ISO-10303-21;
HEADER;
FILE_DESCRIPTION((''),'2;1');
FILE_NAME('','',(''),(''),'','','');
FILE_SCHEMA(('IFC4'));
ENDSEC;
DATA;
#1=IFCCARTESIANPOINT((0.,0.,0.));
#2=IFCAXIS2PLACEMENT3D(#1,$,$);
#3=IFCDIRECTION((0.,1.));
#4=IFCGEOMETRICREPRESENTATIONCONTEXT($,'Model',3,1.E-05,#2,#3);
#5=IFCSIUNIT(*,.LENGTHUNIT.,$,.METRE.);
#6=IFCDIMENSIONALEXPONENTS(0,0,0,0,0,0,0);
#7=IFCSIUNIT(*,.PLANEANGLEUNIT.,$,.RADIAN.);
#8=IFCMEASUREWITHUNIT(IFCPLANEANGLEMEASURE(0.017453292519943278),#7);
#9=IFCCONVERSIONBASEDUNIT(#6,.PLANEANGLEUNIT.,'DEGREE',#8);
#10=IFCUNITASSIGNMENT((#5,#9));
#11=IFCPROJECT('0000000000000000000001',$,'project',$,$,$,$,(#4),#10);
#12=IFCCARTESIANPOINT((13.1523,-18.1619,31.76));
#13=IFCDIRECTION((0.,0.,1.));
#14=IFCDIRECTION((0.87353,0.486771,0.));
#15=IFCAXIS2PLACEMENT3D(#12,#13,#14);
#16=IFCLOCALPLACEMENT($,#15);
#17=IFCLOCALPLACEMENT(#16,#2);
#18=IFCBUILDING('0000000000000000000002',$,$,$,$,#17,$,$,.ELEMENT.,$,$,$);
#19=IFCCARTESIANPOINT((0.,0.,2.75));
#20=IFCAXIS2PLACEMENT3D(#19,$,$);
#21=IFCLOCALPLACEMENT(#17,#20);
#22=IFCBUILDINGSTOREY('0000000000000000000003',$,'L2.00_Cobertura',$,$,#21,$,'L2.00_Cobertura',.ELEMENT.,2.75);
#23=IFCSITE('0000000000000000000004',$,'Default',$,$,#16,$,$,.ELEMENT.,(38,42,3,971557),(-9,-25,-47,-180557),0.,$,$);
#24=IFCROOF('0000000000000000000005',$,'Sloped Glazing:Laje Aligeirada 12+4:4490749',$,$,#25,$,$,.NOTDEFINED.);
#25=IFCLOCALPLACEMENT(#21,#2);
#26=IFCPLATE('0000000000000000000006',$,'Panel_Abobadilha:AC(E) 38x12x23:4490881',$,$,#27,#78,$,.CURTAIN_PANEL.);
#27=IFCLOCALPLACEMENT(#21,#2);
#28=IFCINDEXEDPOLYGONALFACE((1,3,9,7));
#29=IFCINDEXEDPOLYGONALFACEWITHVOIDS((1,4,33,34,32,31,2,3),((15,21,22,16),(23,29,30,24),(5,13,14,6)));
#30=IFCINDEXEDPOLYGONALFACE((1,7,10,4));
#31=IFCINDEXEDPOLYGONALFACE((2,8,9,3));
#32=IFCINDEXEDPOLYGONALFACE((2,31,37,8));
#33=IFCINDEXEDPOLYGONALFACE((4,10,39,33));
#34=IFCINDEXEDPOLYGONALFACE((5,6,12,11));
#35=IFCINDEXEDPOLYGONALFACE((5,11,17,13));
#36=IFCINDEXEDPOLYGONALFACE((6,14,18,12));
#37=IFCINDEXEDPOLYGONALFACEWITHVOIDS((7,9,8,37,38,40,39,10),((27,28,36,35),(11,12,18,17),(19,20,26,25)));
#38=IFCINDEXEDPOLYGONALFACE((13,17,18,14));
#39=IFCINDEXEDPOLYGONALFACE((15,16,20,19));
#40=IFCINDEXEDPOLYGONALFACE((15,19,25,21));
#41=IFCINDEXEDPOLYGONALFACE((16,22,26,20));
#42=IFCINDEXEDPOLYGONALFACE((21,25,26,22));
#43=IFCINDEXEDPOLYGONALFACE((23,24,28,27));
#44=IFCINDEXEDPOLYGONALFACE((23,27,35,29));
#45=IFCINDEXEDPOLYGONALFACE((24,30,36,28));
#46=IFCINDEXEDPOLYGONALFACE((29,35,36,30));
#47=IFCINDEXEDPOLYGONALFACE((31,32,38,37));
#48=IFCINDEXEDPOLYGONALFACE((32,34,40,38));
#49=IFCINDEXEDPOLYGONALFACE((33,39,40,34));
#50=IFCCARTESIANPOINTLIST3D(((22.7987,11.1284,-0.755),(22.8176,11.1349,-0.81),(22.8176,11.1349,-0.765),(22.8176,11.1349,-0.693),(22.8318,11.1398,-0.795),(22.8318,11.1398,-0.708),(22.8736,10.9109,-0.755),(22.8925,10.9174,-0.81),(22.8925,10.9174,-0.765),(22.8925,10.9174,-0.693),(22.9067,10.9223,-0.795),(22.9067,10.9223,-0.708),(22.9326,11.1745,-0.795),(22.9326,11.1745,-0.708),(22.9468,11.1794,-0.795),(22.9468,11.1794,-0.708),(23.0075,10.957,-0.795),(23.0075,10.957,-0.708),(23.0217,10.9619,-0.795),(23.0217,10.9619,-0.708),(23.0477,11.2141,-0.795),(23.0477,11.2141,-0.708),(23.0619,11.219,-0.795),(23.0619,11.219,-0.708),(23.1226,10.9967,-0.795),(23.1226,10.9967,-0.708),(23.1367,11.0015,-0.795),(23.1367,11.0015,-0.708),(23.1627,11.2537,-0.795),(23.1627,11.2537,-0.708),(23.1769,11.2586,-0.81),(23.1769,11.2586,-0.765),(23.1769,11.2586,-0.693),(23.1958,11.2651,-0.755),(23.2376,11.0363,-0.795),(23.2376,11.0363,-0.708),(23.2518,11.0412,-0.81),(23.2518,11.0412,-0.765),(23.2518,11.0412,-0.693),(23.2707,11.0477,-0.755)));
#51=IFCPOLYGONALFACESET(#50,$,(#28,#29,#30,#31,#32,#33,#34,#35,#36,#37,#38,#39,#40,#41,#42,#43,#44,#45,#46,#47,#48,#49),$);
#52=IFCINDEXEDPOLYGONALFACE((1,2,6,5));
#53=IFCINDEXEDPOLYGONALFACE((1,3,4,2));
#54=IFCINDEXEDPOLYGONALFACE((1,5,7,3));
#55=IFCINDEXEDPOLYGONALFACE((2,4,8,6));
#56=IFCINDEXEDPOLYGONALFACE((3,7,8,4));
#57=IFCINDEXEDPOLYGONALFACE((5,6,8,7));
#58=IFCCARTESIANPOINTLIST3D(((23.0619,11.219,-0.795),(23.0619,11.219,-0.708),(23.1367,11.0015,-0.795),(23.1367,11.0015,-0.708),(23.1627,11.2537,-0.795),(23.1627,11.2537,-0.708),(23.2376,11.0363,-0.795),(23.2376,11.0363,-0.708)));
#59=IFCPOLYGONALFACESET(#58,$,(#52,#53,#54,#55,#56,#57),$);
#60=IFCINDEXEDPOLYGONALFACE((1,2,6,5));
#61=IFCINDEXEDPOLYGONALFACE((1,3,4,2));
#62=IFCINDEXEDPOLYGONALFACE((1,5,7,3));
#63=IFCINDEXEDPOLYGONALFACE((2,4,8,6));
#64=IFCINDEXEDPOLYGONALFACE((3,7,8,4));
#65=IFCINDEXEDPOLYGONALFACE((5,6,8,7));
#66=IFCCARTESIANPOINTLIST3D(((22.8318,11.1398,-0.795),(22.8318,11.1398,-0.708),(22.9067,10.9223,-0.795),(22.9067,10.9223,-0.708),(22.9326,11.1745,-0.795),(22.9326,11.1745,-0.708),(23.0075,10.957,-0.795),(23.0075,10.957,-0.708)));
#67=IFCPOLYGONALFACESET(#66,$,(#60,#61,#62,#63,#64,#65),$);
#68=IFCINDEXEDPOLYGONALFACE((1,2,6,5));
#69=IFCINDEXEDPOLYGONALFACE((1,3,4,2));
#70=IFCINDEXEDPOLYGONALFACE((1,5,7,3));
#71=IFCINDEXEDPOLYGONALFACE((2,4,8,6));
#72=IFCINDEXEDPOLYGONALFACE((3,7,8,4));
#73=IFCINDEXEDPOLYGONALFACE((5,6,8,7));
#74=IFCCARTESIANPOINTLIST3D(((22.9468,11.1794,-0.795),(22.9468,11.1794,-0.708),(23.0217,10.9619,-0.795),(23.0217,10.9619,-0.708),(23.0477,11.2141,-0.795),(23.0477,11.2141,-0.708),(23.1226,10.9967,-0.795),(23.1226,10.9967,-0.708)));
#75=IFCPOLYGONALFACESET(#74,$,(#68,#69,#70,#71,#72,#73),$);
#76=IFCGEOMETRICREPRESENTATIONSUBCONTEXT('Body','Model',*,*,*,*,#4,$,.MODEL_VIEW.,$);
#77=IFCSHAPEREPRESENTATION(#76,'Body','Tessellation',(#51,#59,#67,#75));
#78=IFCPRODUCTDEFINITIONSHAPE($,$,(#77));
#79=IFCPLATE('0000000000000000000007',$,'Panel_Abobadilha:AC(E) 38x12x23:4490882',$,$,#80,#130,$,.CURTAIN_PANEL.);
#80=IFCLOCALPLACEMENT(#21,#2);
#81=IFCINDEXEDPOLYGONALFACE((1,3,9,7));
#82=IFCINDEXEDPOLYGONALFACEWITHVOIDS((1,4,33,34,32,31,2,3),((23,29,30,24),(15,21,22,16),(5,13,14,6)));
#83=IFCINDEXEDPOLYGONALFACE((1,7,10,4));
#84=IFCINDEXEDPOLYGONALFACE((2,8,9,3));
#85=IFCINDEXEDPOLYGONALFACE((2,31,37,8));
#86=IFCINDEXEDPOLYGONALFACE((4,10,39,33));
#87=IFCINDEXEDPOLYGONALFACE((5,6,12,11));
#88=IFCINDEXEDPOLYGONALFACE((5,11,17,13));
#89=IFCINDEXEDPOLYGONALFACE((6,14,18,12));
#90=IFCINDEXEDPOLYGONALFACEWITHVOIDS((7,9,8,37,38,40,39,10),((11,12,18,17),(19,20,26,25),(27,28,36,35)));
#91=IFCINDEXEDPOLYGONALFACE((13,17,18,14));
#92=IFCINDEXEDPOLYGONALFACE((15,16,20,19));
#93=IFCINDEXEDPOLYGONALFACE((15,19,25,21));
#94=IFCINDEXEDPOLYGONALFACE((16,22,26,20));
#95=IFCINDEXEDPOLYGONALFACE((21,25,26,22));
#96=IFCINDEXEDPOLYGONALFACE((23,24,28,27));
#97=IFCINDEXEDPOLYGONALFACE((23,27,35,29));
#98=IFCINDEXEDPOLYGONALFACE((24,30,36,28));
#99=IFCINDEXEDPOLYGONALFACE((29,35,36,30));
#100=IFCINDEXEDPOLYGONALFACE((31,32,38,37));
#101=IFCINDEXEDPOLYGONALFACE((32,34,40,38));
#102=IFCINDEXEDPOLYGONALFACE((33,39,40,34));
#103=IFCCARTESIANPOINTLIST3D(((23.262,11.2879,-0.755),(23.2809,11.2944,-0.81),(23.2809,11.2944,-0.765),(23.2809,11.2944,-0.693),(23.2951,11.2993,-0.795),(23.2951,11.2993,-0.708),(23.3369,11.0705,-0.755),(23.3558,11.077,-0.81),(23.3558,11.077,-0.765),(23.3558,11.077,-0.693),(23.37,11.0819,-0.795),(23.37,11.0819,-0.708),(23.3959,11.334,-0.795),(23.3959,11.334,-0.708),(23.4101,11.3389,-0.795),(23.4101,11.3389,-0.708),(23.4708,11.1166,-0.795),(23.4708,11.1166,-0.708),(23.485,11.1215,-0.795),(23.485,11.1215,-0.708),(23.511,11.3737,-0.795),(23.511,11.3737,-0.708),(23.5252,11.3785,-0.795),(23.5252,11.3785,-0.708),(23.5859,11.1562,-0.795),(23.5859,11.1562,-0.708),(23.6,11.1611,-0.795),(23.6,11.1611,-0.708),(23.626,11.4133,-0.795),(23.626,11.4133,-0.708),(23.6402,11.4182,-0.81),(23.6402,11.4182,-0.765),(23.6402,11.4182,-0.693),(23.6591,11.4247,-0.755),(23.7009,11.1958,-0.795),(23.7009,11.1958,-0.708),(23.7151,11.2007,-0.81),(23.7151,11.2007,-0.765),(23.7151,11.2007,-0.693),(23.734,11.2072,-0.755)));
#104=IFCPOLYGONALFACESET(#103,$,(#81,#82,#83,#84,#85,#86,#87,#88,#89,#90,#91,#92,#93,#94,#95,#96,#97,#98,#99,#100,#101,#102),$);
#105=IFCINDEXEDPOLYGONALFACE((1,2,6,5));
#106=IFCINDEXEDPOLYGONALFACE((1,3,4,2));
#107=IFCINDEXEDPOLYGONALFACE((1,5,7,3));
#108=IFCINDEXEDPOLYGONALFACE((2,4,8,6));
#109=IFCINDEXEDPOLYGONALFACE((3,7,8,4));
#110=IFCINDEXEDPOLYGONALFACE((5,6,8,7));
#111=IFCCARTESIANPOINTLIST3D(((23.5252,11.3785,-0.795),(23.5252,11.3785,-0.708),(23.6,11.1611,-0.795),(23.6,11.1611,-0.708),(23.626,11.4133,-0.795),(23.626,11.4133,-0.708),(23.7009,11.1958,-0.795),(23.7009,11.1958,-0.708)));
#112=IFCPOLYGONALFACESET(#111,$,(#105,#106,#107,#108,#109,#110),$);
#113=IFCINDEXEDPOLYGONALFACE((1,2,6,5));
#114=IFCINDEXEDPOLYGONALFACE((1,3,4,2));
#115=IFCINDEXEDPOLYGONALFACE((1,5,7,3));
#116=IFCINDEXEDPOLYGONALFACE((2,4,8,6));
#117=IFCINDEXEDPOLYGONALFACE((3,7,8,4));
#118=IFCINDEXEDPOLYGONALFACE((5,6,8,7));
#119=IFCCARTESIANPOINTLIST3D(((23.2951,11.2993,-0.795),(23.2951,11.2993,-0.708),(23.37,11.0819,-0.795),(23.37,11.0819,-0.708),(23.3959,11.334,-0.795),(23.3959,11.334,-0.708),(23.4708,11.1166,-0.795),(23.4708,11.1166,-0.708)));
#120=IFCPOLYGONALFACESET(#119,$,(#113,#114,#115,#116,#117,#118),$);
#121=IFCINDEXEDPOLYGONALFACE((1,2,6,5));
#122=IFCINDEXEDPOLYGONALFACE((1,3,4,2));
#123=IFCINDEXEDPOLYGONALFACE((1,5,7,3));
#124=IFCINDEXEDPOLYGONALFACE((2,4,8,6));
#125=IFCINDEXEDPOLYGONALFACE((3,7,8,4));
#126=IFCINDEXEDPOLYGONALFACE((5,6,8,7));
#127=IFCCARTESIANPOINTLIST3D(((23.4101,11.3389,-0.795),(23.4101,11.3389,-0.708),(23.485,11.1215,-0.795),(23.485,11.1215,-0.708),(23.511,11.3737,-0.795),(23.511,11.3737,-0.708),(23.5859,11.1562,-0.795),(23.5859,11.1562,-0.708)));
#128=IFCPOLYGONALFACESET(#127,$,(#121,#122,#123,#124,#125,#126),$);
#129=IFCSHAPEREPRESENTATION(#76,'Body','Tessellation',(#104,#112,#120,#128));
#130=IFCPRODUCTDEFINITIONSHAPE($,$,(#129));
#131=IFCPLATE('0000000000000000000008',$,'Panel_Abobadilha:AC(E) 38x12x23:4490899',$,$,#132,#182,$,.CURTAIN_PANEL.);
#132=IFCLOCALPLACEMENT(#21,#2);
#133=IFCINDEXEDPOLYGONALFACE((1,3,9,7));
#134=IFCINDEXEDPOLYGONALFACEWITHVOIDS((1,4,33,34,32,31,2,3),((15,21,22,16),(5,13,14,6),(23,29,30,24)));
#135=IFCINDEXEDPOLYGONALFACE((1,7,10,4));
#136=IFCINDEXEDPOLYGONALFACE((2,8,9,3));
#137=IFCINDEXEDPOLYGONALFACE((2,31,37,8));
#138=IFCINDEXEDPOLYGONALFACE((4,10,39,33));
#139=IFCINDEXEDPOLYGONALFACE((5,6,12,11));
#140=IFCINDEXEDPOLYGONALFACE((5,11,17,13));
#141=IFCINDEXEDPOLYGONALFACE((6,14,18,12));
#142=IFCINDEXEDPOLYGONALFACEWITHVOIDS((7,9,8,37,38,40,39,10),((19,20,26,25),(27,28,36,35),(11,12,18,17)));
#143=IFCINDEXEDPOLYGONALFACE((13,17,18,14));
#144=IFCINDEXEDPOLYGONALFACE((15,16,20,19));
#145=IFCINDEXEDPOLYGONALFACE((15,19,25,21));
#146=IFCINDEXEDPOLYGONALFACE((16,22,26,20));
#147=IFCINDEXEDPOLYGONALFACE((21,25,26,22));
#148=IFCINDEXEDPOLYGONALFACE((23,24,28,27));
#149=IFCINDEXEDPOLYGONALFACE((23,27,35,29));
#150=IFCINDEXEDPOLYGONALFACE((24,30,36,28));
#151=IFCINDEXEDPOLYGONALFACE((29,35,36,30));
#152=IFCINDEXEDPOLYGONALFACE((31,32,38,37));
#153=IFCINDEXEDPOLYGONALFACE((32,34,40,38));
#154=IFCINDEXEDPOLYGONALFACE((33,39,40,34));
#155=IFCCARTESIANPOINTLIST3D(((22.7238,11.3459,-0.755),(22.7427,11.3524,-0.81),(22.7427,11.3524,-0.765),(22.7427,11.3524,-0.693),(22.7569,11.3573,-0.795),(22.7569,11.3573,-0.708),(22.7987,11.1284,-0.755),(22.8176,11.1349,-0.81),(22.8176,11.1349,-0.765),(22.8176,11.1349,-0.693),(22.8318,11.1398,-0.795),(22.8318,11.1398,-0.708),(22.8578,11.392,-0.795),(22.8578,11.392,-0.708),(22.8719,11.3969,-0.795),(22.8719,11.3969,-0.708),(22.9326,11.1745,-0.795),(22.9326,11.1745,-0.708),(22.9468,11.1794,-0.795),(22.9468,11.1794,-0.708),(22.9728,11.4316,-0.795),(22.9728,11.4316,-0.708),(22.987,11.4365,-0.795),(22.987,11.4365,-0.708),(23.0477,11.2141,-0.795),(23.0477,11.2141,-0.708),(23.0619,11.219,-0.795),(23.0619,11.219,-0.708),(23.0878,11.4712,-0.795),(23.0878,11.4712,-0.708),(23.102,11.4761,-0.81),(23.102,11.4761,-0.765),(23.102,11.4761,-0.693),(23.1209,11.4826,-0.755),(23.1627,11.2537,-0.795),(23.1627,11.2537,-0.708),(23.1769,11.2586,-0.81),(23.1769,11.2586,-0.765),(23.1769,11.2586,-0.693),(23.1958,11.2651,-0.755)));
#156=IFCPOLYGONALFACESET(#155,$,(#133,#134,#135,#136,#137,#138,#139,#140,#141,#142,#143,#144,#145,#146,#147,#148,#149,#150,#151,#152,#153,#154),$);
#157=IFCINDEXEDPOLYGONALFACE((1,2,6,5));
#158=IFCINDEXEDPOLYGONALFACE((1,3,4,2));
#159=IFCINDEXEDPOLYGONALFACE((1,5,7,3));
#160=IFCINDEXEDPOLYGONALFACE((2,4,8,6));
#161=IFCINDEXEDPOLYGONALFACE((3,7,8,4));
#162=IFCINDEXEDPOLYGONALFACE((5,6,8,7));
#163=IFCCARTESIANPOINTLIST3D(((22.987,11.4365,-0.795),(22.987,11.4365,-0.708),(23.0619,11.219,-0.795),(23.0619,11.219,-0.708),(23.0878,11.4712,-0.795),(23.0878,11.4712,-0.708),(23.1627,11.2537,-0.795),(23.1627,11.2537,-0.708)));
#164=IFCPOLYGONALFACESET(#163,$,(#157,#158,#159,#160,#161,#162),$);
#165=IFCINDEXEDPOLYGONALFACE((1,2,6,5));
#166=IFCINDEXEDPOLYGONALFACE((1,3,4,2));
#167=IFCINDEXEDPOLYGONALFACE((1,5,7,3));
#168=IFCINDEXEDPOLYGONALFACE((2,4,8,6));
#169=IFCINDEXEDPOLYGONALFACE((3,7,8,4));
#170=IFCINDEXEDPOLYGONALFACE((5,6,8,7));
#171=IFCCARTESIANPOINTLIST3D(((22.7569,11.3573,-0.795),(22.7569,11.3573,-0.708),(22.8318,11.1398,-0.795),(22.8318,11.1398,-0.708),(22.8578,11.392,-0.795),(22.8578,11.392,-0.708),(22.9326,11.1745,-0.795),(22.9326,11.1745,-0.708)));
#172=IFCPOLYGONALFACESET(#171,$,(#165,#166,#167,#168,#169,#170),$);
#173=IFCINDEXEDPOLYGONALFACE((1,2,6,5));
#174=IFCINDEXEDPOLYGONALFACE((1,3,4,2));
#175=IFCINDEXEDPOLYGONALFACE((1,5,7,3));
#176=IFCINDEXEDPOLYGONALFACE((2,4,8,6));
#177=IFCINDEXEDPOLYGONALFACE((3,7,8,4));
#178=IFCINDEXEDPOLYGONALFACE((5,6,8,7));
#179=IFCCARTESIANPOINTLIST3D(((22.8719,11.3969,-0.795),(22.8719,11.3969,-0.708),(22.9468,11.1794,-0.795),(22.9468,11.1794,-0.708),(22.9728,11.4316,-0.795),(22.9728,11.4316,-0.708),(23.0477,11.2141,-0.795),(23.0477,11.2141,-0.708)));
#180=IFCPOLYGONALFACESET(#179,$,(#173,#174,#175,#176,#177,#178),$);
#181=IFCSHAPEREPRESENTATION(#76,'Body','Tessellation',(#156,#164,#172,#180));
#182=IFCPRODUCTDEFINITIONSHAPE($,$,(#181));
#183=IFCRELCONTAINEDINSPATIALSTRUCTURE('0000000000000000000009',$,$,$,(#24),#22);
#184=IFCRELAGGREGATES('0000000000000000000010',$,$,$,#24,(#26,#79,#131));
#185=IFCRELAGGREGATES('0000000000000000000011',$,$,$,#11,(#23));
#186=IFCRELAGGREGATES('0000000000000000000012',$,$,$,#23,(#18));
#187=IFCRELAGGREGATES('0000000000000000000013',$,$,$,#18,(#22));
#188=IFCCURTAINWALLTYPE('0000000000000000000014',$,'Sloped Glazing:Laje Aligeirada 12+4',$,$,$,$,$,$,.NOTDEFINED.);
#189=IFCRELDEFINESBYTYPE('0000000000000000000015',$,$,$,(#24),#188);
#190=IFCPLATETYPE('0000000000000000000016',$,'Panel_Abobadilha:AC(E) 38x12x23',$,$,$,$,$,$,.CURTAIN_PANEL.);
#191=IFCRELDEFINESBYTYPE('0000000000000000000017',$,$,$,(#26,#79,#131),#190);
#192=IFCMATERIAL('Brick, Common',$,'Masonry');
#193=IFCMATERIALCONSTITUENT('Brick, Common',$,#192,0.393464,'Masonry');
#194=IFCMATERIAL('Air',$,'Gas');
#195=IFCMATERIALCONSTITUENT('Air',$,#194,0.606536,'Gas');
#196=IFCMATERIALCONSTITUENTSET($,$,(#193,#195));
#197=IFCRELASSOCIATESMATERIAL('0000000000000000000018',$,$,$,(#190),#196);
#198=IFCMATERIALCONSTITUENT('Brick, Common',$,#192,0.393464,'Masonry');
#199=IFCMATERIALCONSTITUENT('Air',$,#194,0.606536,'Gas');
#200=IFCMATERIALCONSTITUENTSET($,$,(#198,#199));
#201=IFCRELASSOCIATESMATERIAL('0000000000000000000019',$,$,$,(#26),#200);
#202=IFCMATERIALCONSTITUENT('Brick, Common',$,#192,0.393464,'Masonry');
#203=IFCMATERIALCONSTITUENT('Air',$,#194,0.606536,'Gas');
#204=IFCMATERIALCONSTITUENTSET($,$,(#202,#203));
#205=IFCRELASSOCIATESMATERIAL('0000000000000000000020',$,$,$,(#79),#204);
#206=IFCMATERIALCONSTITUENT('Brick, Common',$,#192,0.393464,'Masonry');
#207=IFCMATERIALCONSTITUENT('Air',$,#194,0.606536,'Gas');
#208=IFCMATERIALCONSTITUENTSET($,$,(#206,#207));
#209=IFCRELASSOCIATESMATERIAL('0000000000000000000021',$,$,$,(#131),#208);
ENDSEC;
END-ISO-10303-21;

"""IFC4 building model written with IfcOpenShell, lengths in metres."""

from ifc_helpers import new_model, entity, si_unit, converted_unit, direction, frame, origin, place, context, subcontext, project, spatial, indexed_curve, outline, extrude, source, transform, mapped, material, constituent, constituent_set, type_object, type_shapes, element, aggregate, save


model = new_model("IFC4")

# Units and contexts
model_context = context("Model", 3, precision=1e-05, world=origin(), true_north=direction((0.0, 1.0)))
body_context = subcontext(model_context, "Body", "Model", "MODEL_VIEW")
ifc_project = project(units=[si_unit("LENGTHUNIT", "METRE"), converted_unit("PLANEANGLEUNIT", "DEGREE", entity("IfcPlaneAngleMeasure", 0.017453292519943278), si_unit("PLANEANGLEUNIT", "RADIAN"), dimensions=[0, 0, 0, 0, 0, 0, 0])], contexts=[model_context])

# Site, building, storey
site_placement = place(None, frame((13.1523, -18.1619, 31.76), z_axis=(0.0, 0.0, 1.0), x_axis=(0.87353, 0.486771, 0.0)))
site = spatial("IfcSite", under=ifc_project, at=site_placement, Name="Default", CompositionType="ELEMENT", RefLatitude=(38, 42, 3, 971557), RefLongitude=(-9, -25, -47, -180557), RefElevation=0.0)
building_placement = place(site_placement, origin())
building = spatial("IfcBuilding", under=site, at=building_placement, CompositionType="ELEMENT")
storey_placement = place(building_placement, frame((0.0, 0.0, 2.75)))
storey = spatial("IfcBuildingStorey", under=building, at=storey_placement, Name="L2.00_Cobertura", LongName="L2.00_Cobertura", CompositionType="ELEMENT", Elevation=2.75)

# Roof, plates
curtain_wall_type = type_object("IfcCurtainWallType", Name="Sloped Glazing:Laje Aligeirada 12+4", PredefinedType="NOTDEFINED")
roof_placement = place(storey_placement, frame((0.0, 0.0, -2.75)))
roof = element("IfcRoof", 1, at=roof_placement, inside=storey, type_object=curtain_wall_type, Name="Sloped Glazing:Laje Aligeirada 12+4:4490749", PredefinedType="NOTDEFINED")
ifc_material_1 = material(Name="Brick, Common", Category="Masonry")
ifc_material_2 = material(Name="Air", Category="Gas")
ifc_constituent_1 = constituent(ifc_material_1, Name="Brick, Common", Category="Masonry", fraction=0.393464)
ifc_constituent_2 = constituent(ifc_material_2, Name="Air", Category="Gas", fraction=0.606536)
ifc_constituent_set_1 = constituent_set(constituents=[ifc_constituent_1, ifc_constituent_2])
plate_type_1 = type_object("IfcPlateType", Name="Panel_Abobadilha:AC(E) 38x12x23", PredefinedType="CURTAIN_PANEL", material=ifc_constituent_set_1)
shared_shape_1 = source(origin(), body_context, "Body", "SweptSolid", [
    extrude(outline(indexed_curve([(-0.19, -0.0543), (0.19, -0.0543), (0.19, -0.0093), (0.21, 0.0007), (0.19, 0.0628), (-0.19, 0.0628), (-0.21, 0.0007), (-0.19, -0.0093), (-0.19, -0.0543)], self_intersect=False), holes=[indexed_curve([(-0.0683, 0.0477), (-0.0683, -0.0393), (-0.175, -0.0393), (-0.175, 0.0477), (-0.0683, 0.0477)], self_intersect=False), indexed_curve([(0.0533, 0.0477), (0.0533, -0.0393), (-0.0533, -0.0393), (-0.0533, 0.0477), (0.0533, 0.0477)], self_intersect=False), indexed_curve([(0.175, 0.0477), (0.175, -0.0393), (0.0683, -0.0393), (0.0683, 0.0477), (0.175, 0.0477)], self_intersect=False)]), frame((0.0, 0.0543, 0.0)), (0.0, 0.0, 1.0), 0.23),
    extrude(outline(indexed_curve([(-0.0533, -0.0435), (0.0533, -0.0435), (0.0533, 0.0435), (-0.0533, 0.0435), (-0.0533, -0.0435)], self_intersect=False)), frame((0.1217, 0.0585, 0.0), z_axis=(0.0, 0.0, 1.0), x_axis=(-1.0, 0.0, 0.0)), (0.0, 0.0, 1.0), 0.23),
    extrude(outline(indexed_curve([(-0.0533, -0.0435), (0.0533, -0.0435), (0.0533, 0.0435), (-0.0533, 0.0435), (-0.0533, -0.0435)], self_intersect=False)), frame((-0.1217, 0.0585, 0.0), z_axis=(0.0, 0.0, 1.0), x_axis=(-1.0, 0.0, 0.0)), (0.0, 0.0, 1.0), 0.23),
    extrude(outline(indexed_curve([(-0.0533, -0.0435), (0.0533, -0.0435), (0.0533, 0.0435), (-0.0533, 0.0435), (-0.0533, -0.0435)], self_intersect=False)), frame((0.0, 0.0585, 0.0), z_axis=(0.0, 0.0, 1.0), x_axis=(-1.0, 0.0, 0.0)), (0.0, 0.0, 1.0), 0.23),
])
type_shapes(plate_type_1, [shared_shape_1])
ifc_constituent_3 = constituent(ifc_material_1, Name="Brick, Common", Category="Masonry", fraction=0.393464)
ifc_constituent_4 = constituent(ifc_material_2, Name="Air", Category="Gas", fraction=0.606536)
ifc_constituent_set_2 = constituent_set(constituents=[ifc_constituent_3, ifc_constituent_4])
plate_1_placement = place(roof_placement, frame((22.9973, 11.1968, 1.94), z_axis=(0.325568, -0.945519, 0.0), x_axis=(0.945519, 0.325568, 0.0)))
plate_1 = element("IfcPlate", 2, at=plate_1_placement, type_object=plate_type_1, material=ifc_constituent_set_2, Name="Panel_Abobadilha:AC(E) 38x12x23:4490881", PredefinedType="CURTAIN_PANEL", context=body_context, shape_type="MappedRepresentation", body=[
    mapped(shared_shape_1, transform((0.0, 0.0, 0.0), scale=1.0)),
])
ifc_constituent_5 = constituent(ifc_material_1, Name="Brick, Common", Category="Masonry", fraction=0.393464)
ifc_constituent_6 = constituent(ifc_material_2, Name="Air", Category="Gas", fraction=0.606536)
ifc_constituent_set_3 = constituent_set(constituents=[ifc_constituent_5, ifc_constituent_6])
plate_2_placement = place(roof_placement, frame((23.4606, 11.3563, 1.94), z_axis=(0.325568, -0.945519, 0.0), x_axis=(0.945519, 0.325568, 0.0)))
plate_2 = element("IfcPlate", 3, at=plate_2_placement, type_object=plate_type_1, material=ifc_constituent_set_3, Name="Panel_Abobadilha:AC(E) 38x12x23:4490882", PredefinedType="CURTAIN_PANEL", context=body_context, shape_type="MappedRepresentation", body=[
    mapped(shared_shape_1, transform((0.0, 0.0, 0.0), scale=1.0)),
])
ifc_constituent_7 = constituent(ifc_material_1, Name="Brick, Common", Category="Masonry", fraction=0.393464)
ifc_constituent_8 = constituent(ifc_material_2, Name="Air", Category="Gas", fraction=0.606536)
ifc_constituent_set_4 = constituent_set(constituents=[ifc_constituent_7, ifc_constituent_8])
plate_3_placement = place(roof_placement, frame((22.9224, 11.4142, 1.94), z_axis=(0.325568, -0.945519, 0.0), x_axis=(0.945519, 0.325568, 0.0)))
plate_3 = element("IfcPlate", 4, at=plate_3_placement, type_object=plate_type_1, material=ifc_constituent_set_4, Name="Panel_Abobadilha:AC(E) 38x12x23:4490899", PredefinedType="CURTAIN_PANEL", context=body_context, shape_type="MappedRepresentation", body=[
    mapped(shared_shape_1, transform((0.0, 0.0, 0.0), scale=1.0)),
])
aggregate(roof, [plate_1, plate_2, plate_3])

save(model, "model.ifc")
